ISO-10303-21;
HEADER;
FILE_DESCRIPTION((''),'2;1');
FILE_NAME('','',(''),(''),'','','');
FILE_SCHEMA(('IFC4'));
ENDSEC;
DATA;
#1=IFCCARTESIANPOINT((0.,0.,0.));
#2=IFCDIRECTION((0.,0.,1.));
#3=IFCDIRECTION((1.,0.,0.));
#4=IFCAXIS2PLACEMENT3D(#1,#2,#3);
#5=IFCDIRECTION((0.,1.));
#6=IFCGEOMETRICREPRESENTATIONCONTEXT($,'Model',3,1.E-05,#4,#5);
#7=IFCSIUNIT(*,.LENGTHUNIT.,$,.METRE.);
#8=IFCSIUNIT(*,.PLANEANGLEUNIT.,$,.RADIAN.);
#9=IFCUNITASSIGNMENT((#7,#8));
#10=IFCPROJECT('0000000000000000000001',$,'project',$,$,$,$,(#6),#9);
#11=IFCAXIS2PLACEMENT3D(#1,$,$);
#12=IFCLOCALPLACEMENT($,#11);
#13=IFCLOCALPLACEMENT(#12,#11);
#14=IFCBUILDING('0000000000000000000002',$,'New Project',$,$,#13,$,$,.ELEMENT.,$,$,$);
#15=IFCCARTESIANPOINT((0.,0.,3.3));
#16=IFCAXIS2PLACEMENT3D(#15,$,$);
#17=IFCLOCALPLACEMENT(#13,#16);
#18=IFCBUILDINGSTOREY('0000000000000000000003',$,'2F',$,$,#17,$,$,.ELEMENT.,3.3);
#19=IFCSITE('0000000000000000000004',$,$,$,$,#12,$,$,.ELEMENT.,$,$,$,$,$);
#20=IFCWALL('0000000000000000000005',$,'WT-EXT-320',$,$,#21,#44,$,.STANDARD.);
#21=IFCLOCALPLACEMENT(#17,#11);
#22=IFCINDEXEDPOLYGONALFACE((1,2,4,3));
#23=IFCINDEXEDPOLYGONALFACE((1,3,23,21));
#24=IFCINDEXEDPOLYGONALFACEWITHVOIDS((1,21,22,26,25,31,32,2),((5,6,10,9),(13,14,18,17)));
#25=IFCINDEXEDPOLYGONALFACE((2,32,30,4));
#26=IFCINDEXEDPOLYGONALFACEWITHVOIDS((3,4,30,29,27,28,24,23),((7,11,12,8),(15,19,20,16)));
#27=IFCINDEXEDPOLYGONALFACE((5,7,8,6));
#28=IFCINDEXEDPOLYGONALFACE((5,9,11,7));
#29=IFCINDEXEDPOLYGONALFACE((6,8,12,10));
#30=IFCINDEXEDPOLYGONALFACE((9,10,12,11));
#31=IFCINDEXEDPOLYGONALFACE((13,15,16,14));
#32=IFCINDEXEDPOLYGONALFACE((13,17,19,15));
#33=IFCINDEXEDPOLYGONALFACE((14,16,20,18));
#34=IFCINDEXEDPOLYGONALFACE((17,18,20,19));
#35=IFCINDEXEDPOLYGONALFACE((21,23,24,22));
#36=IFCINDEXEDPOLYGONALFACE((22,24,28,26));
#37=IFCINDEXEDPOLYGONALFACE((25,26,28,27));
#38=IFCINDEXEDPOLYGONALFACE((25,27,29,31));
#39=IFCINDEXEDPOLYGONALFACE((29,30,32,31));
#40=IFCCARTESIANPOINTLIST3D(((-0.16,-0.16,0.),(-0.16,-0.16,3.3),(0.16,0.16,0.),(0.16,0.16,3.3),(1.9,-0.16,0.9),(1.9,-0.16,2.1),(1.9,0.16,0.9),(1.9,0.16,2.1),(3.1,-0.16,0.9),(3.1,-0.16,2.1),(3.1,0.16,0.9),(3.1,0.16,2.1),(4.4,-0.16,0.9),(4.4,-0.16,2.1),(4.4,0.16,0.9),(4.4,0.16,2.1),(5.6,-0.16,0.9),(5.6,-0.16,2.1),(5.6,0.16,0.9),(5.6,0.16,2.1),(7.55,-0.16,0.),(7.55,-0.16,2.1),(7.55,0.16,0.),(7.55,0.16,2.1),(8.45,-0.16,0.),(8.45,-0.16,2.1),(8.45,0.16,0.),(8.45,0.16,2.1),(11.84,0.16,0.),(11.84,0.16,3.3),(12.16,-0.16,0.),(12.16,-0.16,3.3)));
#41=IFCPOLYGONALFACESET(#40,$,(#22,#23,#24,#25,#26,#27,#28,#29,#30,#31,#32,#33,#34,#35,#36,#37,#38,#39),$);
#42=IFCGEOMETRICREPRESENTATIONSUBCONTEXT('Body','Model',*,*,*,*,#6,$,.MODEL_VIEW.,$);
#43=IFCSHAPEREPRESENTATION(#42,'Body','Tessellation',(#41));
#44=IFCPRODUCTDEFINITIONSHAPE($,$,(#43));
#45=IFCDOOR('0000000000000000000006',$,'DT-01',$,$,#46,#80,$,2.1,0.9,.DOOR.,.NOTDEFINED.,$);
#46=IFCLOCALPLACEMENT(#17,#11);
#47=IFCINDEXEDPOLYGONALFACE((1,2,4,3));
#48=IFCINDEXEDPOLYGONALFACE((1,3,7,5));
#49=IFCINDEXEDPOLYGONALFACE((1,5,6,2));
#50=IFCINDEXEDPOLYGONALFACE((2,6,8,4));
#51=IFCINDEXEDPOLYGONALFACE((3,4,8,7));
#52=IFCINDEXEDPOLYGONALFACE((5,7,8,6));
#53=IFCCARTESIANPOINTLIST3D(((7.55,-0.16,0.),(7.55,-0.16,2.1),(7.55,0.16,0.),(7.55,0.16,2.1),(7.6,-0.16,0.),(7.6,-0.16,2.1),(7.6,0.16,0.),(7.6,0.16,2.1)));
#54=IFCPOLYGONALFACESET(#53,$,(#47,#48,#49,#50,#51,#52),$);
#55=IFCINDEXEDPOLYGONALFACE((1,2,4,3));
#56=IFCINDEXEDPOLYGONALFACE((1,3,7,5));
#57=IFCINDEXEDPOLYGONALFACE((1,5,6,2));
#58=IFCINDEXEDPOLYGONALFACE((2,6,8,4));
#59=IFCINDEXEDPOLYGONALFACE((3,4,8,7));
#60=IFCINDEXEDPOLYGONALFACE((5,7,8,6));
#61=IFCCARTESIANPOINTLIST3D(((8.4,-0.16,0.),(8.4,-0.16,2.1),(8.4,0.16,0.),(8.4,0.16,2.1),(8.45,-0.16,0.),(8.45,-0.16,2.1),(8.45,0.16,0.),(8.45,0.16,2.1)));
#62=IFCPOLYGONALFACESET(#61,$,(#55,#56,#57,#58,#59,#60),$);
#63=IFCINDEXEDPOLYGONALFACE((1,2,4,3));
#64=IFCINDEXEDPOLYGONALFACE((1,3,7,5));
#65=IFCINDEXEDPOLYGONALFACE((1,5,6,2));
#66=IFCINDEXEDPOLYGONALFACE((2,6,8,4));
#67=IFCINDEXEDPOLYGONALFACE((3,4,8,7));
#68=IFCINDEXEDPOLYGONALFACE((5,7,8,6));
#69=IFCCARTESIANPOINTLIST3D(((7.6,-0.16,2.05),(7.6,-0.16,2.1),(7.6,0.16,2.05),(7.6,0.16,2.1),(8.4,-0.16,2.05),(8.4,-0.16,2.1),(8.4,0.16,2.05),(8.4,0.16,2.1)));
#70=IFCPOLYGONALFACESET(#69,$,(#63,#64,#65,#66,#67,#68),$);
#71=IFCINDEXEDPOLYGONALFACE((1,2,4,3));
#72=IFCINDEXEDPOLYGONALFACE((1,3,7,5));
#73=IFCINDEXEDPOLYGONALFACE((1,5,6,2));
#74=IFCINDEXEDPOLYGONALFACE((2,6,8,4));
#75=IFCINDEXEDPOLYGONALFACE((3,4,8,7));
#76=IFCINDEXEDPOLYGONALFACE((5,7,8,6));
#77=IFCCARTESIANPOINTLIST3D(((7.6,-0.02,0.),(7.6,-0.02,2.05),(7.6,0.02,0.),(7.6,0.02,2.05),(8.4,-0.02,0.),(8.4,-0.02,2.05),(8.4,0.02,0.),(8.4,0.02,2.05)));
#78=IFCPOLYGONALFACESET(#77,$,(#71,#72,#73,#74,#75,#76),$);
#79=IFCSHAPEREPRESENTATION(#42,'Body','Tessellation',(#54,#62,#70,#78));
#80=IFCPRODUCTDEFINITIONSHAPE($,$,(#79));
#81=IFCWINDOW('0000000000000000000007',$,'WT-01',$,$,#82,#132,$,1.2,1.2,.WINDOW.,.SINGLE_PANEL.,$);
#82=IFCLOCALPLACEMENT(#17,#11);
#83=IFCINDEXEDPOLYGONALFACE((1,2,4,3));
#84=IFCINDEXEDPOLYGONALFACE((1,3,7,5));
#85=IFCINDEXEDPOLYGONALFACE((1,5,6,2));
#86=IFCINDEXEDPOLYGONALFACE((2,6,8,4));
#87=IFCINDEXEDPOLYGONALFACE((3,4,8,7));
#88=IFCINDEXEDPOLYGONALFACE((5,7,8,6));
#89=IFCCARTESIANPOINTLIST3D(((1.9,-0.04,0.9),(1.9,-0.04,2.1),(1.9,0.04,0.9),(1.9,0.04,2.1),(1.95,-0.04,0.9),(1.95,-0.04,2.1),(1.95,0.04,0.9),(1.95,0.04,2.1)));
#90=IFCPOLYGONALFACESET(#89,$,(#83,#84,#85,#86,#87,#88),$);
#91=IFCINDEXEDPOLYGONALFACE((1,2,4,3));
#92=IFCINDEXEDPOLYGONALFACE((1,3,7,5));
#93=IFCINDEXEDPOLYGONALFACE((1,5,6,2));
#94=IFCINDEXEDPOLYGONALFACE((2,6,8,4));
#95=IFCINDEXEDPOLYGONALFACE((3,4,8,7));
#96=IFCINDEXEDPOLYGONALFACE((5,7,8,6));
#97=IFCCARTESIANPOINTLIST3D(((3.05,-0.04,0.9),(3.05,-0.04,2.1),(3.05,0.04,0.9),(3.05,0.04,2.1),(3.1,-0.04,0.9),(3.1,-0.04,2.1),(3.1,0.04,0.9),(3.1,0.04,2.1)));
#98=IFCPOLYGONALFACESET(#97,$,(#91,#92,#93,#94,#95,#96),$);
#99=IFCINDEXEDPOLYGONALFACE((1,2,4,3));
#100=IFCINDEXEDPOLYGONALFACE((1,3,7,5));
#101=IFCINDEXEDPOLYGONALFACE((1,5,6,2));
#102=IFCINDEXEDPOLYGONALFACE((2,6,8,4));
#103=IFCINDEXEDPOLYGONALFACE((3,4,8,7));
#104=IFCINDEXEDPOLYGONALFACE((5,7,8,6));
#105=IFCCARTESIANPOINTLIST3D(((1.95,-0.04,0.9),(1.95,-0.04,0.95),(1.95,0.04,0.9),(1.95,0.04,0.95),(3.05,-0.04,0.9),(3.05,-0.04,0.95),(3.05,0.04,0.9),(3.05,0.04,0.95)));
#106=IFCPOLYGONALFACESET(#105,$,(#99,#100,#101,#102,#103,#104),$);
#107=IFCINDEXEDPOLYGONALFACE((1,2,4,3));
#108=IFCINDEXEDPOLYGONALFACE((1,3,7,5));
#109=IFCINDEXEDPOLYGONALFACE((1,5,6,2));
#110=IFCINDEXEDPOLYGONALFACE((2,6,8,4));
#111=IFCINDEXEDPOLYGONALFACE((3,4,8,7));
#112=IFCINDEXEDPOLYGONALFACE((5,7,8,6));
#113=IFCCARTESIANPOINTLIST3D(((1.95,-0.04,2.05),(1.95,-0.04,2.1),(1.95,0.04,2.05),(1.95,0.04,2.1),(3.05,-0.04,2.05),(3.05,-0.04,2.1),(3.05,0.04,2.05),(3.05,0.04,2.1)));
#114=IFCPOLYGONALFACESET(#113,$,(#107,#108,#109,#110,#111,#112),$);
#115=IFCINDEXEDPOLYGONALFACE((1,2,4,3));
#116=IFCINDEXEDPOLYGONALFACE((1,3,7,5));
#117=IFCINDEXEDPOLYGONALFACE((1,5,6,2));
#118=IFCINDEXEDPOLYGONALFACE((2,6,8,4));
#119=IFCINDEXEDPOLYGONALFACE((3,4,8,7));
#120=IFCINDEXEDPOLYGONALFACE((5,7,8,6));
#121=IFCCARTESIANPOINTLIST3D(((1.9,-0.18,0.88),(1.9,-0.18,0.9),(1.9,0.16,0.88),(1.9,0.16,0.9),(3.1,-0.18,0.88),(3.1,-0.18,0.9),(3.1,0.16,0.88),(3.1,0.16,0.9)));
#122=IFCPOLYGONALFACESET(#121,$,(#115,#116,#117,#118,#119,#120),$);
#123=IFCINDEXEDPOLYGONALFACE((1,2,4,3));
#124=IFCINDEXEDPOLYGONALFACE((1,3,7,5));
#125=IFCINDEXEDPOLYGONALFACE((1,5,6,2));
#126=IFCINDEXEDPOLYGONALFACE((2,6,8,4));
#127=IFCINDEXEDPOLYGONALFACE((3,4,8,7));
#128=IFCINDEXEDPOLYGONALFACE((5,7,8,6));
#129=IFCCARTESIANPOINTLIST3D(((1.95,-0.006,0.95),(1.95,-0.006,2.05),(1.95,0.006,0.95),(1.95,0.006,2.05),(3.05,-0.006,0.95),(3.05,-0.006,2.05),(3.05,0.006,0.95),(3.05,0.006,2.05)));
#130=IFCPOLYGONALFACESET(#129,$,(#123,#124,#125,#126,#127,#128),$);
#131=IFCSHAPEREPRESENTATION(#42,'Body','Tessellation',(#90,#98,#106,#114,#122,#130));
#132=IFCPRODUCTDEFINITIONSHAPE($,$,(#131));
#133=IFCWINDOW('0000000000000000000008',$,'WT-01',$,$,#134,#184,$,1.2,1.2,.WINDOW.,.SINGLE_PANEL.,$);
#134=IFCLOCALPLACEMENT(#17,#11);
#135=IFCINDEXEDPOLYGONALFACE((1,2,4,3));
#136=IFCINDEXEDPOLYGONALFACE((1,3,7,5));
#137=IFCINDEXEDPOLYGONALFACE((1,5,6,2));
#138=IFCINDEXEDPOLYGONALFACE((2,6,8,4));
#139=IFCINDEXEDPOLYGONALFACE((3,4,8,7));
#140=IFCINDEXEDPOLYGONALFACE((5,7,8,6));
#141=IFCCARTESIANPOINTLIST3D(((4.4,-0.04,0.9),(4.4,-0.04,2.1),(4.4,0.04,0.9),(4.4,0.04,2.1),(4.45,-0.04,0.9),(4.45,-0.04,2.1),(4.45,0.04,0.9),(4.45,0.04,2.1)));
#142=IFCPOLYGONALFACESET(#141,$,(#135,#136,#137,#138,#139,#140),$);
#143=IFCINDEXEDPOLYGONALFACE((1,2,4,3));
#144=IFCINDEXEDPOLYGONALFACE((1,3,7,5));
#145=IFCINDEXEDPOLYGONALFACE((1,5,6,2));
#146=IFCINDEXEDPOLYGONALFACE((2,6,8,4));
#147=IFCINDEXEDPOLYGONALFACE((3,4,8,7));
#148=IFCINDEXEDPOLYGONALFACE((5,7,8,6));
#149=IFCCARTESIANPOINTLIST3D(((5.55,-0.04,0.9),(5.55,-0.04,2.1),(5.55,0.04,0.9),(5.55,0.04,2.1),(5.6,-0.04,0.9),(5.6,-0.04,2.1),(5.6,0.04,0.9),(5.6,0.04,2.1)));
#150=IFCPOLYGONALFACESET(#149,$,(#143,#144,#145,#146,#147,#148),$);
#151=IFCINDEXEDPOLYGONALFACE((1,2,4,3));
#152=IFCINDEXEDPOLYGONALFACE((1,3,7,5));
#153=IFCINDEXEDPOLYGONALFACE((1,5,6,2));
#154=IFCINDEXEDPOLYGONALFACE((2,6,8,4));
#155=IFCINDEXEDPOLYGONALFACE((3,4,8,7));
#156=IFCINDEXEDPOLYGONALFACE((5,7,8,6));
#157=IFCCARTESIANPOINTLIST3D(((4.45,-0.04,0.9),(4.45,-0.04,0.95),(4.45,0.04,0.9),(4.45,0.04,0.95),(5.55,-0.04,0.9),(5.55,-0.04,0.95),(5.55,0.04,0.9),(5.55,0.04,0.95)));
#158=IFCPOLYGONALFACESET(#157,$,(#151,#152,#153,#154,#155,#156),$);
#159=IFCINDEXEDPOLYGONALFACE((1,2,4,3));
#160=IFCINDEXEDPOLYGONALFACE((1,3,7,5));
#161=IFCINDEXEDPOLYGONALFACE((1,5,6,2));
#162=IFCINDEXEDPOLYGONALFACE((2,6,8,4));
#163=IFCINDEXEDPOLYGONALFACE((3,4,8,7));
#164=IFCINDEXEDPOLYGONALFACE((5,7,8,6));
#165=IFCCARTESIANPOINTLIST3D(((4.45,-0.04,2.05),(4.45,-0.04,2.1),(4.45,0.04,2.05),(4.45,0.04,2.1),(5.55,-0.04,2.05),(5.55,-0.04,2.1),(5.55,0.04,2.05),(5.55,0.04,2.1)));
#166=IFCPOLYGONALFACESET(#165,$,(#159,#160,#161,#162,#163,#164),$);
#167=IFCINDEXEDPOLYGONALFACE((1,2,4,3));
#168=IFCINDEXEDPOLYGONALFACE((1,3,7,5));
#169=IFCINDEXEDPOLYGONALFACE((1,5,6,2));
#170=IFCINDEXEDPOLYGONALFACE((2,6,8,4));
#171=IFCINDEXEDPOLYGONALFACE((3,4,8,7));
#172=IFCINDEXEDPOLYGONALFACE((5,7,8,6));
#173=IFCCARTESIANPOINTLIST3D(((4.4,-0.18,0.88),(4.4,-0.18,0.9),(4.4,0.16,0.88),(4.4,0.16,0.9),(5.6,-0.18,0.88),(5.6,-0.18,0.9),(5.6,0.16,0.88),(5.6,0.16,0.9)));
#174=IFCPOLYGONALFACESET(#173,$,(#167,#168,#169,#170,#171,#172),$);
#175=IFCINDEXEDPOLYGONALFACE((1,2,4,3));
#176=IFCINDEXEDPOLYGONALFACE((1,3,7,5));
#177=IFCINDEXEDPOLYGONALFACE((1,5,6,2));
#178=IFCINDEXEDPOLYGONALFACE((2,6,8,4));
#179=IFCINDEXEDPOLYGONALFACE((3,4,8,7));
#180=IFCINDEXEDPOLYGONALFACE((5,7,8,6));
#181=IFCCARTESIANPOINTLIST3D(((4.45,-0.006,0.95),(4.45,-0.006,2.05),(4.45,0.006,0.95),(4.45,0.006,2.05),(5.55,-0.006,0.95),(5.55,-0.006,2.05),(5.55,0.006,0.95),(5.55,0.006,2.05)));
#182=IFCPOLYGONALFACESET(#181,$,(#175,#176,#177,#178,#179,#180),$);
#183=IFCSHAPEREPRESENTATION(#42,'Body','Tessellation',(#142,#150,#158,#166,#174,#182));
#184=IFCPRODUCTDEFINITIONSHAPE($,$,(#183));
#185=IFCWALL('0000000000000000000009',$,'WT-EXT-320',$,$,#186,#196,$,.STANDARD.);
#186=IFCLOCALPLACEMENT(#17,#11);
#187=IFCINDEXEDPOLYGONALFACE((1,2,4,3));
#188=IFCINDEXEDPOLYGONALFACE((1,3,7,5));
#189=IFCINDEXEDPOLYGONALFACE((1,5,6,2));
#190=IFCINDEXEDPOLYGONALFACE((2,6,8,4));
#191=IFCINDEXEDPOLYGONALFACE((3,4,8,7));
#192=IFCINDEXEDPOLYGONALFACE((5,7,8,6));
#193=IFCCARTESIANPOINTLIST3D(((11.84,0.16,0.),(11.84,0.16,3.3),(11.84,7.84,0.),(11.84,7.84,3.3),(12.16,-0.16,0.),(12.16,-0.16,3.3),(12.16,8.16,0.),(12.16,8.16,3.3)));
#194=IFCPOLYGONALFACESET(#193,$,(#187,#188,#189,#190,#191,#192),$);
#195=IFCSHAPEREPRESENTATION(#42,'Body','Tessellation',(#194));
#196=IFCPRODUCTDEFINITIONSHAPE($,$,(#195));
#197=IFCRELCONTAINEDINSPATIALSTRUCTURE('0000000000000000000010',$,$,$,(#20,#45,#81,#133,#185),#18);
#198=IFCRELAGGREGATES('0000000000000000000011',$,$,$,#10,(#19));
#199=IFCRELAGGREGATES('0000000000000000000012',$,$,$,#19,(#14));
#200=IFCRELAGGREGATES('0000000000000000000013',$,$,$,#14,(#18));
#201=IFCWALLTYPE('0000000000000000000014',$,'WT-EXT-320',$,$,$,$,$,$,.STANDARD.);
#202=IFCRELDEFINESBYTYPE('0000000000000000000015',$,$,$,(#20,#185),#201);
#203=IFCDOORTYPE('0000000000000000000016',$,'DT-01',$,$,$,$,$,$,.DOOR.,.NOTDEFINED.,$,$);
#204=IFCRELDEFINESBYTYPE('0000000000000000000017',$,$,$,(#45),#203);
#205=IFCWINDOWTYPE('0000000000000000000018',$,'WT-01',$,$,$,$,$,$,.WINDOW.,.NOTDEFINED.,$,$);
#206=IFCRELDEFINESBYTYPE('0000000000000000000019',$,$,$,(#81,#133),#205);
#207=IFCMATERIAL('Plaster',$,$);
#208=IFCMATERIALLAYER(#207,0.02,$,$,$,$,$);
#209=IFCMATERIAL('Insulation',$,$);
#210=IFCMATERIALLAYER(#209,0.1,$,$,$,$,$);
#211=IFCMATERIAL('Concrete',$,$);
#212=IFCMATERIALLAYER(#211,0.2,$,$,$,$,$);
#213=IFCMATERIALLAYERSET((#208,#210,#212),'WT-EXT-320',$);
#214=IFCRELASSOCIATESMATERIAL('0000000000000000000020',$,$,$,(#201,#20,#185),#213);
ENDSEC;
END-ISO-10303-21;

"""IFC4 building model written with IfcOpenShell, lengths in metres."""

from ifc_helpers import new_model, si_unit, direction, frame, frame_2d, origin, origin_with_axes, place, context, subcontext, project, spatial, polyline, rectangle, outline, extrude, material, layer, layer_set, layer_usage, type_object, element, fill, save


model = new_model("IFC4")

# Units and contexts
model_context = context("Model", 3, precision=1e-05, world=origin_with_axes(), true_north=direction((0.0, 1.0)))
body_context = subcontext(model_context, "Body", "Model", "MODEL_VIEW")
ifc_project = project(units=[si_unit("LENGTHUNIT", "METRE"), si_unit("PLANEANGLEUNIT", "RADIAN")], contexts=[model_context])

# Site, building, storey
site_placement = place(None, origin())
site = spatial("IfcSite", under=ifc_project, at=site_placement, CompositionType="ELEMENT")
building_placement = place(site_placement, origin())
building = spatial("IfcBuilding", under=site, at=building_placement, Name="New Project", CompositionType="ELEMENT")
storey_placement = place(building_placement, frame((0.0, 0.0, 3.3)))
storey = spatial("IfcBuildingStorey", under=building, at=storey_placement, Name="2F", CompositionType="ELEMENT", Elevation=3.3)

# Shared definitions
ifc_material_1 = material(Name="Concrete")

# Wall, openings, door, windows
ifc_material_2 = material(Name="Plaster")
ifc_layer_1 = layer(ifc_material_2, 0.02)
ifc_material_3 = material(Name="Insulation")
ifc_layer_2 = layer(ifc_material_3, 0.1)
ifc_layer_3 = layer(ifc_material_1, 0.2)
ifc_layer_set_1 = layer_set([ifc_layer_1, ifc_layer_2, ifc_layer_3], Name="WT-EXT-320")
ifc_layer_usage_1 = layer_usage(ifc_layer_set_1, "AXIS2", "NEGATIVE", 0.16)
wall_type_1 = type_object("IfcWallType", Name="WT-EXT-320", PredefinedType="STANDARD", material=ifc_layer_set_1)
wall_1_placement = place(storey_placement, origin())
wall_1 = element("IfcWall", 1, at=wall_1_placement, inside=storey, type_object=wall_type_1, material=ifc_layer_usage_1, Name="WT-EXT-320", PredefinedType="STANDARD", context=body_context, shape_type="SweptSolid", body=[
    extrude(outline(polyline([(-0.16, -0.16), (12.16, -0.16), (11.84, 0.16), (0.16, 0.16), (-0.16, -0.16)])), origin(), (0.0, 0.0, 1.0), 3.3),
])
opening_1_placement = place(wall_1_placement, frame((7.55, 0.0, 0.0)))
opening_1 = element("IfcOpeningElement", 2, at=opening_1_placement, cuts=wall_1, PredefinedType="OPENING", context=body_context, shape_type="SweptSolid", body=[
    extrude(rectangle(XDim=0.9, YDim=0.42, at=frame_2d((0.45, 0.0))), origin(), (0.0, 0.0, 1.0), 2.1),
])
opening_2_placement = place(wall_1_placement, frame((1.9, 0.0, 0.9)))
opening_2 = element("IfcOpeningElement", 3, at=opening_2_placement, cuts=wall_1, PredefinedType="OPENING", context=body_context, shape_type="SweptSolid", body=[
    extrude(rectangle(XDim=1.2, YDim=0.42, at=frame_2d((0.6, 0.0))), origin(), (0.0, 0.0, 1.0), 1.2),
])
opening_3_placement = place(wall_1_placement, frame((4.4, 0.0, 0.9)))
opening_3 = element("IfcOpeningElement", 4, at=opening_3_placement, cuts=wall_1, PredefinedType="OPENING", context=body_context, shape_type="SweptSolid", body=[
    extrude(rectangle(XDim=1.2, YDim=0.42, at=frame_2d((0.6, 0.0))), origin(), (0.0, 0.0, 1.0), 1.2),
])
door_type_1 = type_object("IfcDoorType", Name="DT-01", OperationType="NOTDEFINED", PredefinedType="DOOR")
door_1_placement = place(opening_1_placement, origin())
door_1 = element("IfcDoor", 5, at=door_1_placement, inside=storey, type_object=door_type_1, Name="DT-01", OperationType="NOTDEFINED", OverallHeight=2.1, OverallWidth=0.9, PredefinedType="DOOR", context=body_context, shape_type="SweptSolid", body=[
    extrude(outline(polyline([(0.0, -0.16), (0.05, -0.16), (0.05, 0.16), (0.0, 0.16), (0.0, -0.16)])), origin(), (0.0, 0.0, 1.0), 2.1),
    extrude(outline(polyline([(0.85, -0.16), (0.9, -0.16), (0.9, 0.16), (0.85, 0.16), (0.85, -0.16)])), origin(), (0.0, 0.0, 1.0), 2.1),
    extrude(outline(polyline([(0.05, -0.16), (0.85, -0.16), (0.85, 0.16), (0.05, 0.16), (0.05, -0.16)])), frame((0.0, 0.0, 2.05)), (0.0, 0.0, 1.0), 0.05),
    extrude(outline(polyline([(0.05, -0.02), (0.85, -0.02), (0.85, 0.02), (0.05, 0.02), (0.05, -0.02)])), origin(), (0.0, 0.0, 1.0), 2.05),
])
fill(opening_1, door_1)
window_type_1 = type_object("IfcWindowType", Name="WT-01", PartitioningType="NOTDEFINED", PredefinedType="WINDOW")
window_1_placement = place(opening_2_placement, origin())
window_1 = element("IfcWindow", 6, at=window_1_placement, inside=storey, type_object=window_type_1, Name="WT-01", OverallHeight=1.2, OverallWidth=1.2, PartitioningType="SINGLE_PANEL", PredefinedType="WINDOW", context=body_context, shape_type="SweptSolid", body=[
    extrude(outline(polyline([(0.0, -0.04), (0.05, -0.04), (0.05, 0.04), (0.0, 0.04), (0.0, -0.04)])), origin(), (0.0, 0.0, 1.0), 1.2),
    extrude(outline(polyline([(1.15, -0.04), (1.2, -0.04), (1.2, 0.04), (1.15, 0.04), (1.15, -0.04)])), origin(), (0.0, 0.0, 1.0), 1.2),
    extrude(outline(polyline([(0.05, -0.04), (1.15, -0.04), (1.15, 0.04), (0.05, 0.04), (0.05, -0.04)])), origin(), (0.0, 0.0, 1.0), 0.05),
    extrude(outline(polyline([(0.05, -0.04), (1.15, -0.04), (1.15, 0.04), (0.05, 0.04), (0.05, -0.04)])), frame((0.0, 0.0, 1.15)), (0.0, 0.0, 1.0), 0.05),
    extrude(outline(polyline([(0.0, -0.18), (1.2, -0.18), (1.2, 0.16), (0.0, 0.16), (0.0, -0.18)])), frame((0.0, 0.0, -0.02)), (0.0, 0.0, 1.0), 0.02),
    extrude(outline(polyline([(0.05, -0.006), (1.15, -0.006), (1.15, 0.006), (0.05, 0.006), (0.05, -0.006)])), frame((0.0, 0.0, 0.05)), (0.0, 0.0, 1.0), 1.1),
])
fill(opening_2, window_1)
window_2_placement = place(opening_3_placement, origin())
window_2 = element("IfcWindow", 7, at=window_2_placement, inside=storey, type_object=window_type_1, Name="WT-01", OverallHeight=1.2, OverallWidth=1.2, PartitioningType="SINGLE_PANEL", PredefinedType="WINDOW", context=body_context, shape_type="SweptSolid", body=[
    extrude(outline(polyline([(0.0, -0.04), (0.05, -0.04), (0.05, 0.04), (0.0, 0.04), (0.0, -0.04)])), origin(), (0.0, 0.0, 1.0), 1.2),
    extrude(outline(polyline([(1.15, -0.04), (1.2, -0.04), (1.2, 0.04), (1.15, 0.04), (1.15, -0.04)])), origin(), (0.0, 0.0, 1.0), 1.2),
    extrude(outline(polyline([(0.05, -0.04), (1.15, -0.04), (1.15, 0.04), (0.05, 0.04), (0.05, -0.04)])), origin(), (0.0, 0.0, 1.0), 0.05),
    extrude(outline(polyline([(0.05, -0.04), (1.15, -0.04), (1.15, 0.04), (0.05, 0.04), (0.05, -0.04)])), frame((0.0, 0.0, 1.15)), (0.0, 0.0, 1.0), 0.05),
    extrude(outline(polyline([(0.0, -0.18), (1.2, -0.18), (1.2, 0.16), (0.0, 0.16), (0.0, -0.18)])), frame((0.0, 0.0, -0.02)), (0.0, 0.0, 1.0), 0.02),
    extrude(outline(polyline([(0.05, -0.006), (1.15, -0.006), (1.15, 0.006), (0.05, 0.006), (0.05, -0.006)])), frame((0.0, 0.0, 0.05)), (0.0, 0.0, 1.0), 1.1),
])
fill(opening_3, window_2)

# Wall
wall_2_placement = place(storey_placement, frame((12.0, 0.0, 0.0), z_axis=(0.0, 0.0, 1.0), x_axis=(0.0, 1.0, 0.0)))
element("IfcWall", 8, at=wall_2_placement, inside=storey, type_object=wall_type_1, material=ifc_layer_usage_1, Name="WT-EXT-320", PredefinedType="STANDARD", context=body_context, shape_type="SweptSolid", body=[
    extrude(outline(polyline([(-0.16, -0.16), (8.16, -0.16), (7.84, 0.16), (0.16, 0.16), (-0.16, -0.16)])), origin(), (0.0, 0.0, 1.0), 3.3),
])

save(model, "model.ifc")
